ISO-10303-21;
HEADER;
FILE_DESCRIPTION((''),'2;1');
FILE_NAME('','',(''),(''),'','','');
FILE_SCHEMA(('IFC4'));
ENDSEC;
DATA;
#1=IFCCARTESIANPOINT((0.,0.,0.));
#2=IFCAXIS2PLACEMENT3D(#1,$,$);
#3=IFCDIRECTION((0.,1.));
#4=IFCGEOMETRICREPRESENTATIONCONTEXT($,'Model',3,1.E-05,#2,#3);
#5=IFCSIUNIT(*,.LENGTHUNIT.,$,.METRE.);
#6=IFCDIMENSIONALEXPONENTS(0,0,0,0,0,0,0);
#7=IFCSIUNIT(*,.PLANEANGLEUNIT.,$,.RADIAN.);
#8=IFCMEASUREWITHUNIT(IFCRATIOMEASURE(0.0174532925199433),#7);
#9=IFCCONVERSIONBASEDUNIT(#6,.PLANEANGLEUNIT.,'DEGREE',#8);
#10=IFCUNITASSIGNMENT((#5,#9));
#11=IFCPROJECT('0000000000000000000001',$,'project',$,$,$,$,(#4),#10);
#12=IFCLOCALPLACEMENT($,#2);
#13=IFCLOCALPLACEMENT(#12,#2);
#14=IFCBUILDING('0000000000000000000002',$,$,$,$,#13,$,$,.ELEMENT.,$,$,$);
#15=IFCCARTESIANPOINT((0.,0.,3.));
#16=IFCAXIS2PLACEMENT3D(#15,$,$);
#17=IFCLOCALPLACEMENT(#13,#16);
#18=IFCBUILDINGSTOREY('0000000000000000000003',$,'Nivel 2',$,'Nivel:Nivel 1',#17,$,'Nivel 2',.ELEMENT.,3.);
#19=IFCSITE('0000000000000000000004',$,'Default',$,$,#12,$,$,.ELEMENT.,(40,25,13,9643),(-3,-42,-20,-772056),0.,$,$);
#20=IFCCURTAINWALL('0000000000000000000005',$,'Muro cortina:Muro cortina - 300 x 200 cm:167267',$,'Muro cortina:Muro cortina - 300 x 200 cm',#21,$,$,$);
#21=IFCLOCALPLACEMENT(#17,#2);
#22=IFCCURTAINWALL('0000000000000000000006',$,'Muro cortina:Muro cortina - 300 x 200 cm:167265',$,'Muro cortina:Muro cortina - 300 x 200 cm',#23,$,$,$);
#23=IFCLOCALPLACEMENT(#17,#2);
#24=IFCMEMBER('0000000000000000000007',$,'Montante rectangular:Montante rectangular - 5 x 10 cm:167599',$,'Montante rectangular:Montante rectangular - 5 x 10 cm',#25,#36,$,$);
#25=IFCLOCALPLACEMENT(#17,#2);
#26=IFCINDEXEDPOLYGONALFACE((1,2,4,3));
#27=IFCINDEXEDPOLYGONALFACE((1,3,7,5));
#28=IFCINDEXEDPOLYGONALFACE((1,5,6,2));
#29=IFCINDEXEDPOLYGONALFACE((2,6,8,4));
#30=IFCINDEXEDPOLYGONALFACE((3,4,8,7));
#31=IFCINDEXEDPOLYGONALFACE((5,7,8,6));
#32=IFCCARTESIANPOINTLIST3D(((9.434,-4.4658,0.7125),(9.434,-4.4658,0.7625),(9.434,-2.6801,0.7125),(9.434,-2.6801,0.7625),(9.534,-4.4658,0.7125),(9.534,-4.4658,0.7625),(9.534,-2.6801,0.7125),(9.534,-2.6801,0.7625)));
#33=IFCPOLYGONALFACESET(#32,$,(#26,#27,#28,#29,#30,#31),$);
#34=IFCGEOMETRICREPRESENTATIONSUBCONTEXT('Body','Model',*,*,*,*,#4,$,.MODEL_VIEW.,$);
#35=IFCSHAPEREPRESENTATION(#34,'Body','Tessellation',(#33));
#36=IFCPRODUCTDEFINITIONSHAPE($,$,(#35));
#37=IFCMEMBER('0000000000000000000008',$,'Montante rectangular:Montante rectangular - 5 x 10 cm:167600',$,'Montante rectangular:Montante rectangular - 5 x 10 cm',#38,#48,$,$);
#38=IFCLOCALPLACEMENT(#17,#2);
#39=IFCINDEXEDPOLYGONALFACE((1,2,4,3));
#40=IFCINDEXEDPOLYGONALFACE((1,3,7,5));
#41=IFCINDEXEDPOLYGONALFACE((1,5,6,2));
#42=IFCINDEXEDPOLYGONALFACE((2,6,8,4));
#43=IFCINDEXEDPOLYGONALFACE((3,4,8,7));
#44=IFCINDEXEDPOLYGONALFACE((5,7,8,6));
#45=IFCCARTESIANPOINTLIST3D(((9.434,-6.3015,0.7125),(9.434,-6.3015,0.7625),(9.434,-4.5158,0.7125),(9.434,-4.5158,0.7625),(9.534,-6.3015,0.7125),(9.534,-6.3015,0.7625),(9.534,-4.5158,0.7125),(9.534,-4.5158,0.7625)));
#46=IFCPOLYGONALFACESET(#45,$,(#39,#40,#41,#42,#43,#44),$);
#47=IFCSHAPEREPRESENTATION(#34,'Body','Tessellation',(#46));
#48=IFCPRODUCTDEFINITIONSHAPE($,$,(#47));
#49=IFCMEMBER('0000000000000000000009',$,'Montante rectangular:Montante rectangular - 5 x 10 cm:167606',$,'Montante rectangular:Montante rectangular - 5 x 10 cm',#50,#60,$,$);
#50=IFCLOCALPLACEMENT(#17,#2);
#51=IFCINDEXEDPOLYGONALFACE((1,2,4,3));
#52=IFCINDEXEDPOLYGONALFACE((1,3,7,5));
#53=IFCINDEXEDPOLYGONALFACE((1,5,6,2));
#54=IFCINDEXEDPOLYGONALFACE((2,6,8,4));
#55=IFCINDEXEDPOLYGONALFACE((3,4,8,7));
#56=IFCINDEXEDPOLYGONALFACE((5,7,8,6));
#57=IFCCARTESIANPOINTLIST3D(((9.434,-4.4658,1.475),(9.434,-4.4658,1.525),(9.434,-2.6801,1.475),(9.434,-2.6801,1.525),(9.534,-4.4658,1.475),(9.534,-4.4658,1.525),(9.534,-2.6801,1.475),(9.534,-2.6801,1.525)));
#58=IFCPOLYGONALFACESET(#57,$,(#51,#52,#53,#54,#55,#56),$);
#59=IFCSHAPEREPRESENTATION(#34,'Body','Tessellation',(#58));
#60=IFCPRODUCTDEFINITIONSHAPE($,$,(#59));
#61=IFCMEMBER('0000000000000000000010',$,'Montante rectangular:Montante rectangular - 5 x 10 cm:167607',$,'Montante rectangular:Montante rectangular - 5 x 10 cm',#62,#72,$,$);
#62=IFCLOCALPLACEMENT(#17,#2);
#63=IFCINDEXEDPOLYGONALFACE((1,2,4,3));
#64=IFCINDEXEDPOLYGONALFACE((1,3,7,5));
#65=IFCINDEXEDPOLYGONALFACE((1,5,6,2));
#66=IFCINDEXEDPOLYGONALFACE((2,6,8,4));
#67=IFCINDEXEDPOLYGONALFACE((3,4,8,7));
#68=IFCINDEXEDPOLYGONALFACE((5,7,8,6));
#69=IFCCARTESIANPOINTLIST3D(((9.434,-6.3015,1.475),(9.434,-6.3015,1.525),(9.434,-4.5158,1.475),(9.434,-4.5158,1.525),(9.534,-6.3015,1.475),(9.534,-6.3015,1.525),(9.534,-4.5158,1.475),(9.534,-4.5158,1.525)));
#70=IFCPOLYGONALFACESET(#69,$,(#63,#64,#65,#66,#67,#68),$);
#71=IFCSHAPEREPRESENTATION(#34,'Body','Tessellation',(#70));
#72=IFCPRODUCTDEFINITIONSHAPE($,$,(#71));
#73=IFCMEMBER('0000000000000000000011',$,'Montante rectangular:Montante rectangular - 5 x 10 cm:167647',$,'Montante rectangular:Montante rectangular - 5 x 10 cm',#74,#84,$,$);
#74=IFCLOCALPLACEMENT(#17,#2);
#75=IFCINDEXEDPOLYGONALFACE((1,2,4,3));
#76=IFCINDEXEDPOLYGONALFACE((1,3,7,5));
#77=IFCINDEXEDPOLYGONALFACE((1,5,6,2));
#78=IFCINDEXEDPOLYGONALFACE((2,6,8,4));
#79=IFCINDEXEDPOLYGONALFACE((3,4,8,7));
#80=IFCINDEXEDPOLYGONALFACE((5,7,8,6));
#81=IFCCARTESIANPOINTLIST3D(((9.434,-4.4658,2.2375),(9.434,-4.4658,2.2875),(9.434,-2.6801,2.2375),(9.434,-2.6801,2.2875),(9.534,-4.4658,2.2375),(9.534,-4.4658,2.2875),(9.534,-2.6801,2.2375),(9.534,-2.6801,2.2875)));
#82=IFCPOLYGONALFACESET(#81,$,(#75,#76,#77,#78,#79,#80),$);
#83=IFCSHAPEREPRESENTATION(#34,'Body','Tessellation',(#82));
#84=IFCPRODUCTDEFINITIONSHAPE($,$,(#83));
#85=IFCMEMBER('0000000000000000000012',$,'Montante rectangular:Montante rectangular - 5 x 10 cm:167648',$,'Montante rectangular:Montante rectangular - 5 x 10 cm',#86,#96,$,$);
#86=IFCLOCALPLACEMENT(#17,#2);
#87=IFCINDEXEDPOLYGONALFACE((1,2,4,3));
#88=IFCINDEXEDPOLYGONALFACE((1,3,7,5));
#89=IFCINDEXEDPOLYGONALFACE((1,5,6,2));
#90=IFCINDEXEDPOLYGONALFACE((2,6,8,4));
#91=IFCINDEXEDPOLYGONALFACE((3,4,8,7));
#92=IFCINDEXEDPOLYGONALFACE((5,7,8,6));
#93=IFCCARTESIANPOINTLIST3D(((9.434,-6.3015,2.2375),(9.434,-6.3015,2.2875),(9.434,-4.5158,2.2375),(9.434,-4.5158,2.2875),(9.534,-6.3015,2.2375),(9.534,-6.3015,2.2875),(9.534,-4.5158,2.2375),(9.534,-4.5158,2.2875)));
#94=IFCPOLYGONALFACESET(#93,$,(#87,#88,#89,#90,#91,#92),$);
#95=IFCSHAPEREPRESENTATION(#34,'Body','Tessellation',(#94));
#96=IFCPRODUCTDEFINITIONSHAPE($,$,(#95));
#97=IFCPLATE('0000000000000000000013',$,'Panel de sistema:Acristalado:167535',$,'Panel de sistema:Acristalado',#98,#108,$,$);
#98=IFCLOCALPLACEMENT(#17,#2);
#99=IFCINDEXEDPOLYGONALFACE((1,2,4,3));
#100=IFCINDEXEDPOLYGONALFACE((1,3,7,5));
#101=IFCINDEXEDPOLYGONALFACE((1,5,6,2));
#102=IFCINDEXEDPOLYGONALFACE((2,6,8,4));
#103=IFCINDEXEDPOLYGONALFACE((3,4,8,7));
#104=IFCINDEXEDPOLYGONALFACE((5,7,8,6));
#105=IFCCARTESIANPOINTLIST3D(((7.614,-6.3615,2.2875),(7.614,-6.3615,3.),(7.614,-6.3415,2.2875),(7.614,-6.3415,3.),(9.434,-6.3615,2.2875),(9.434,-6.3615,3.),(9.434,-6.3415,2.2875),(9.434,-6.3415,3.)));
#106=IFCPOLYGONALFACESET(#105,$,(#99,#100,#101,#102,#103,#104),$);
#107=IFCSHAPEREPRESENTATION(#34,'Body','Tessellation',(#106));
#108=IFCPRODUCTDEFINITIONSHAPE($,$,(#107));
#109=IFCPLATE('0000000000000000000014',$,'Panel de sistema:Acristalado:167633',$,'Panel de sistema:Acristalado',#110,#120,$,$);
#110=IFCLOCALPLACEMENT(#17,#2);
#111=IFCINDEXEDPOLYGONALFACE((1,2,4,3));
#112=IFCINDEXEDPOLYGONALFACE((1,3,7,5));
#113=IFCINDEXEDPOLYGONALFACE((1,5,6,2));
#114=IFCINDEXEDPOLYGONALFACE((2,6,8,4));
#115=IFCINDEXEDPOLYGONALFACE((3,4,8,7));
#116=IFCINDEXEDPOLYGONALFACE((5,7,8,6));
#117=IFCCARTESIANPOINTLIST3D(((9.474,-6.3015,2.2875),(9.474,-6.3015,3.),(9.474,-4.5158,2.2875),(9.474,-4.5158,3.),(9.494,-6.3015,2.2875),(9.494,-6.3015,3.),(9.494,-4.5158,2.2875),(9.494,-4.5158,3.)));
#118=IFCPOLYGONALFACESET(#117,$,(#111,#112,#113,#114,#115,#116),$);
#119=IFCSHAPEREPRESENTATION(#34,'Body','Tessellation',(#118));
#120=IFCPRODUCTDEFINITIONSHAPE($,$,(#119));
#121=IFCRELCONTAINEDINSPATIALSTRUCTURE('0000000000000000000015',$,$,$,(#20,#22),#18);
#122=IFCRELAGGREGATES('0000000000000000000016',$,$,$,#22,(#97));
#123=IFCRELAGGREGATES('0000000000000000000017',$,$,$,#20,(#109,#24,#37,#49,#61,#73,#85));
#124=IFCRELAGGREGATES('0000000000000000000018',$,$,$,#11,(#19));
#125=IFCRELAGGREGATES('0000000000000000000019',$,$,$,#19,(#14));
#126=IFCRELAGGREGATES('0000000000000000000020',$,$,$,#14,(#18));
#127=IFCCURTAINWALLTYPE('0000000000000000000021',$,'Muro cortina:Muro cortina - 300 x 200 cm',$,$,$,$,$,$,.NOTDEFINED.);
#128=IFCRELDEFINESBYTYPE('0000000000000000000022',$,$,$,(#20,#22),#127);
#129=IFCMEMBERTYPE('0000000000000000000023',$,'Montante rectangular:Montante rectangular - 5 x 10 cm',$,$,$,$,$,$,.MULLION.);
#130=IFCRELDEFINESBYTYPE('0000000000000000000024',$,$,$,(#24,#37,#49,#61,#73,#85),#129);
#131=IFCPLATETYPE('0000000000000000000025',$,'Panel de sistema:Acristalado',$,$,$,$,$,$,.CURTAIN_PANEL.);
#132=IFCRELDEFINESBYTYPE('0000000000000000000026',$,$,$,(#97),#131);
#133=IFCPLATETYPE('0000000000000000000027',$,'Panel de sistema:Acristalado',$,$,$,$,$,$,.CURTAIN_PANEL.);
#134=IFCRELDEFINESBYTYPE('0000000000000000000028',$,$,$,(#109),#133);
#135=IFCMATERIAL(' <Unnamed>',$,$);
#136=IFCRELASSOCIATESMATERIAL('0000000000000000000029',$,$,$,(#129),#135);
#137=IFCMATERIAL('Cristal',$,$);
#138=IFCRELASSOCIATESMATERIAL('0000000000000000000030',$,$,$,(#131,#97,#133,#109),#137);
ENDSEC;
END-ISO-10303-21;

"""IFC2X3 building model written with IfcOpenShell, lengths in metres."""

from ifc_helpers import new_model, entity, si_unit, converted_unit, direction, frame, origin, origin_2d_with_axis, place, context, subcontext, project, spatial, rectangle, extrude, source, transform, mapped, material, type_object, type_shapes, element, aggregate, save


model = new_model("IFC2X3")

# Units and contexts
model_context = context("Model", 3, precision=1e-05, world=origin(), true_north=direction((0.0, 1.0)))
body_context = subcontext(model_context, "Body", "Model", "MODEL_VIEW")
ifc_project = project(units=[si_unit("LENGTHUNIT", "METRE"), converted_unit("PLANEANGLEUNIT", "DEGREE", entity("IfcRatioMeasure", 0.0174532925199433), si_unit("PLANEANGLEUNIT", "RADIAN"), dimensions=[0, 0, 0, 0, 0, 0, 0])], contexts=[model_context])

# Site, building, storey
site_placement = place(None, origin())
site = spatial("IfcSite", under=ifc_project, at=site_placement, Name="Default", CompositionType="ELEMENT", RefLatitude=(40, 25, 13, 9643), RefLongitude=(-3, -42, -20, -772056), RefElevation=0.0)
building_placement = place(site_placement, origin())
building = spatial("IfcBuilding", under=site, at=building_placement, CompositionType="ELEMENT")
storey_placement = place(building_placement, frame((0.0, 0.0, 3.0)))
storey = spatial("IfcBuildingStorey", under=building, at=storey_placement, Name="Nivel 2", ObjectType="Nivel:Nivel 1", LongName="Nivel 2", CompositionType="ELEMENT", Elevation=3.0)

# Curtain walls
curtain_wall_type = type_object("IfcCurtainWallType", Name="Muro cortina:Muro cortina - 300 x 200 cm", PredefinedType="NOTDEFINED")
curtain_wall_1_placement = place(storey_placement, frame((0.0, 0.0, -3.0)))
curtain_wall_1 = element("IfcCurtainWall", 1, at=curtain_wall_1_placement, inside=storey, type_object=curtain_wall_type, Name="Muro cortina:Muro cortina - 300 x 200 cm:167267", ObjectType="Muro cortina:Muro cortina - 300 x 200 cm")
ifc_material_1 = material(Name=" <Unnamed>")
curtain_wall_2_placement = place(storey_placement, frame((0.0, 0.0, -3.0)))
curtain_wall_2 = element("IfcCurtainWall", 2, at=curtain_wall_2_placement, inside=storey, type_object=curtain_wall_type, Name="Muro cortina:Muro cortina - 300 x 200 cm:167265", ObjectType="Muro cortina:Muro cortina - 300 x 200 cm")

# Members
member_type_1 = type_object("IfcMemberType", Name="Montante rectangular:Montante rectangular - 5 x 10 cm", PredefinedType="MULLION", material=ifc_material_1)
shared_shape_1 = source(origin(), body_context, "Body", "SweptSolid", [
    extrude(rectangle(XDim=0.1, YDim=0.05, at=origin_2d_with_axis()), frame((0.0, 0.0, -1.7857), z_axis=(0.0, 0.0, 1.0), x_axis=(0.0, -1.0, 0.0)), (0.0, 0.0, 1.0), 1.7857),
])
type_shapes(member_type_1, [shared_shape_1])
member_1_placement = place(storey_placement, frame((9.484, -4.4658, 0.7375), z_axis=(0.0, -1.0, 0.0), x_axis=(0.0, 0.0, 1.0)))
member_1 = element("IfcMember", 3, at=member_1_placement, type_object=member_type_1, Name="Montante rectangular:Montante rectangular - 5 x 10 cm:167599", ObjectType="Montante rectangular:Montante rectangular - 5 x 10 cm", context=body_context, shape_type="MappedRepresentation", body=[
    mapped(shared_shape_1, transform((0.0, 0.0, 0.0), scale=1.0)),
])
member_2_placement = place(storey_placement, frame((9.484, -6.3015, 0.7375), z_axis=(0.0, -1.0, 0.0), x_axis=(0.0, 0.0, 1.0)))
member_2 = element("IfcMember", 4, at=member_2_placement, type_object=member_type_1, Name="Montante rectangular:Montante rectangular - 5 x 10 cm:167600", ObjectType="Montante rectangular:Montante rectangular - 5 x 10 cm", context=body_context, shape_type="MappedRepresentation", body=[
    mapped(shared_shape_1, transform((0.0, 0.0, 0.0), scale=1.0)),
])
member_3_placement = place(storey_placement, frame((9.484, -4.4658, 1.5), z_axis=(0.0, -1.0, 0.0), x_axis=(0.0, 0.0, 1.0)))
member_3 = element("IfcMember", 5, at=member_3_placement, type_object=member_type_1, Name="Montante rectangular:Montante rectangular - 5 x 10 cm:167606", ObjectType="Montante rectangular:Montante rectangular - 5 x 10 cm", context=body_context, shape_type="MappedRepresentation", body=[
    mapped(shared_shape_1, transform((0.0, 0.0, 0.0), scale=1.0)),
])
member_4_placement = place(storey_placement, frame((9.484, -6.3015, 1.5), z_axis=(0.0, -1.0, 0.0), x_axis=(0.0, 0.0, 1.0)))
member_4 = element("IfcMember", 6, at=member_4_placement, type_object=member_type_1, Name="Montante rectangular:Montante rectangular - 5 x 10 cm:167607", ObjectType="Montante rectangular:Montante rectangular - 5 x 10 cm", context=body_context, shape_type="MappedRepresentation", body=[
    mapped(shared_shape_1, transform((0.0, 0.0, 0.0), scale=1.0)),
])
member_5_placement = place(storey_placement, frame((9.484, -4.4658, 2.2625), z_axis=(0.0, -1.0, 0.0), x_axis=(0.0, 0.0, 1.0)))
member_5 = element("IfcMember", 7, at=member_5_placement, type_object=member_type_1, Name="Montante rectangular:Montante rectangular - 5 x 10 cm:167647", ObjectType="Montante rectangular:Montante rectangular - 5 x 10 cm", context=body_context, shape_type="MappedRepresentation", body=[
    mapped(shared_shape_1, transform((0.0, 0.0, 0.0), scale=1.0)),
])
member_6_placement = place(storey_placement, frame((9.484, -6.3015, 2.2625), z_axis=(0.0, -1.0, 0.0), x_axis=(0.0, 0.0, 1.0)))
member_6 = element("IfcMember", 8, at=member_6_placement, type_object=member_type_1, Name="Montante rectangular:Montante rectangular - 5 x 10 cm:167648", ObjectType="Montante rectangular:Montante rectangular - 5 x 10 cm", context=body_context, shape_type="MappedRepresentation", body=[
    mapped(shared_shape_1, transform((0.0, 0.0, 0.0), scale=1.0)),
])

# Plates
ifc_material_2 = material(Name="Cristal")
plate_type_1 = type_object("IfcPlateType", Name="Panel de sistema:Acristalado", PredefinedType="CURTAIN_PANEL", material=ifc_material_2)
shared_shape_2 = source(origin(), body_context, "Body", "SweptSolid", [
    extrude(rectangle(XDim=0.02, YDim=1.82, at=origin_2d_with_axis()), frame((0.0, 0.0, 0.0), z_axis=(0.0, 0.0, 1.0), x_axis=(0.0, 1.0, 0.0)), (0.0, 0.0, 1.0), 0.7125),
])
type_shapes(plate_type_1, [shared_shape_2])
plate_1_placement = place(curtain_wall_2_placement, frame((8.524, -6.3515, 5.2875), z_axis=(0.0, 0.0, 1.0), x_axis=(-1.0, 0.0, 0.0)))
plate_1 = element("IfcPlate", 9, at=plate_1_placement, type_object=plate_type_1, material=ifc_material_2, Name="Panel de sistema:Acristalado:167535", ObjectType="Panel de sistema:Acristalado", context=body_context, shape_type="MappedRepresentation", body=[
    mapped(shared_shape_2, transform((0.0, 0.0, 0.0), scale=1.0)),
])
aggregate(curtain_wall_2, [plate_1])
plate_type_2 = type_object("IfcPlateType", Name="Panel de sistema:Acristalado", PredefinedType="CURTAIN_PANEL", material=ifc_material_2)
shared_shape_3 = source(origin(), body_context, "Body", "SweptSolid", [
    extrude(rectangle(XDim=0.02, YDim=1.7857, at=origin_2d_with_axis()), frame((0.0, 0.0, 0.0), z_axis=(0.0, 0.0, 1.0), x_axis=(0.0, 1.0, 0.0)), (0.0, 0.0, 1.0), 0.7125),
])
type_shapes(plate_type_2, [shared_shape_3])
plate_2_placement = place(curtain_wall_1_placement, frame((9.484, -5.4087, 5.2875), z_axis=(0.0, 0.0, 1.0), x_axis=(0.0, -1.0, 0.0)))
plate_2 = element("IfcPlate", 10, at=plate_2_placement, type_object=plate_type_2, material=ifc_material_2, Name="Panel de sistema:Acristalado:167633", ObjectType="Panel de sistema:Acristalado", context=body_context, shape_type="MappedRepresentation", body=[
    mapped(shared_shape_3, transform((0.0, 0.0, 0.0), scale=1.0)),
])
aggregate(curtain_wall_1, [plate_2, member_1, member_2, member_3, member_4, member_5, member_6])

save(model, "model.ifc")
